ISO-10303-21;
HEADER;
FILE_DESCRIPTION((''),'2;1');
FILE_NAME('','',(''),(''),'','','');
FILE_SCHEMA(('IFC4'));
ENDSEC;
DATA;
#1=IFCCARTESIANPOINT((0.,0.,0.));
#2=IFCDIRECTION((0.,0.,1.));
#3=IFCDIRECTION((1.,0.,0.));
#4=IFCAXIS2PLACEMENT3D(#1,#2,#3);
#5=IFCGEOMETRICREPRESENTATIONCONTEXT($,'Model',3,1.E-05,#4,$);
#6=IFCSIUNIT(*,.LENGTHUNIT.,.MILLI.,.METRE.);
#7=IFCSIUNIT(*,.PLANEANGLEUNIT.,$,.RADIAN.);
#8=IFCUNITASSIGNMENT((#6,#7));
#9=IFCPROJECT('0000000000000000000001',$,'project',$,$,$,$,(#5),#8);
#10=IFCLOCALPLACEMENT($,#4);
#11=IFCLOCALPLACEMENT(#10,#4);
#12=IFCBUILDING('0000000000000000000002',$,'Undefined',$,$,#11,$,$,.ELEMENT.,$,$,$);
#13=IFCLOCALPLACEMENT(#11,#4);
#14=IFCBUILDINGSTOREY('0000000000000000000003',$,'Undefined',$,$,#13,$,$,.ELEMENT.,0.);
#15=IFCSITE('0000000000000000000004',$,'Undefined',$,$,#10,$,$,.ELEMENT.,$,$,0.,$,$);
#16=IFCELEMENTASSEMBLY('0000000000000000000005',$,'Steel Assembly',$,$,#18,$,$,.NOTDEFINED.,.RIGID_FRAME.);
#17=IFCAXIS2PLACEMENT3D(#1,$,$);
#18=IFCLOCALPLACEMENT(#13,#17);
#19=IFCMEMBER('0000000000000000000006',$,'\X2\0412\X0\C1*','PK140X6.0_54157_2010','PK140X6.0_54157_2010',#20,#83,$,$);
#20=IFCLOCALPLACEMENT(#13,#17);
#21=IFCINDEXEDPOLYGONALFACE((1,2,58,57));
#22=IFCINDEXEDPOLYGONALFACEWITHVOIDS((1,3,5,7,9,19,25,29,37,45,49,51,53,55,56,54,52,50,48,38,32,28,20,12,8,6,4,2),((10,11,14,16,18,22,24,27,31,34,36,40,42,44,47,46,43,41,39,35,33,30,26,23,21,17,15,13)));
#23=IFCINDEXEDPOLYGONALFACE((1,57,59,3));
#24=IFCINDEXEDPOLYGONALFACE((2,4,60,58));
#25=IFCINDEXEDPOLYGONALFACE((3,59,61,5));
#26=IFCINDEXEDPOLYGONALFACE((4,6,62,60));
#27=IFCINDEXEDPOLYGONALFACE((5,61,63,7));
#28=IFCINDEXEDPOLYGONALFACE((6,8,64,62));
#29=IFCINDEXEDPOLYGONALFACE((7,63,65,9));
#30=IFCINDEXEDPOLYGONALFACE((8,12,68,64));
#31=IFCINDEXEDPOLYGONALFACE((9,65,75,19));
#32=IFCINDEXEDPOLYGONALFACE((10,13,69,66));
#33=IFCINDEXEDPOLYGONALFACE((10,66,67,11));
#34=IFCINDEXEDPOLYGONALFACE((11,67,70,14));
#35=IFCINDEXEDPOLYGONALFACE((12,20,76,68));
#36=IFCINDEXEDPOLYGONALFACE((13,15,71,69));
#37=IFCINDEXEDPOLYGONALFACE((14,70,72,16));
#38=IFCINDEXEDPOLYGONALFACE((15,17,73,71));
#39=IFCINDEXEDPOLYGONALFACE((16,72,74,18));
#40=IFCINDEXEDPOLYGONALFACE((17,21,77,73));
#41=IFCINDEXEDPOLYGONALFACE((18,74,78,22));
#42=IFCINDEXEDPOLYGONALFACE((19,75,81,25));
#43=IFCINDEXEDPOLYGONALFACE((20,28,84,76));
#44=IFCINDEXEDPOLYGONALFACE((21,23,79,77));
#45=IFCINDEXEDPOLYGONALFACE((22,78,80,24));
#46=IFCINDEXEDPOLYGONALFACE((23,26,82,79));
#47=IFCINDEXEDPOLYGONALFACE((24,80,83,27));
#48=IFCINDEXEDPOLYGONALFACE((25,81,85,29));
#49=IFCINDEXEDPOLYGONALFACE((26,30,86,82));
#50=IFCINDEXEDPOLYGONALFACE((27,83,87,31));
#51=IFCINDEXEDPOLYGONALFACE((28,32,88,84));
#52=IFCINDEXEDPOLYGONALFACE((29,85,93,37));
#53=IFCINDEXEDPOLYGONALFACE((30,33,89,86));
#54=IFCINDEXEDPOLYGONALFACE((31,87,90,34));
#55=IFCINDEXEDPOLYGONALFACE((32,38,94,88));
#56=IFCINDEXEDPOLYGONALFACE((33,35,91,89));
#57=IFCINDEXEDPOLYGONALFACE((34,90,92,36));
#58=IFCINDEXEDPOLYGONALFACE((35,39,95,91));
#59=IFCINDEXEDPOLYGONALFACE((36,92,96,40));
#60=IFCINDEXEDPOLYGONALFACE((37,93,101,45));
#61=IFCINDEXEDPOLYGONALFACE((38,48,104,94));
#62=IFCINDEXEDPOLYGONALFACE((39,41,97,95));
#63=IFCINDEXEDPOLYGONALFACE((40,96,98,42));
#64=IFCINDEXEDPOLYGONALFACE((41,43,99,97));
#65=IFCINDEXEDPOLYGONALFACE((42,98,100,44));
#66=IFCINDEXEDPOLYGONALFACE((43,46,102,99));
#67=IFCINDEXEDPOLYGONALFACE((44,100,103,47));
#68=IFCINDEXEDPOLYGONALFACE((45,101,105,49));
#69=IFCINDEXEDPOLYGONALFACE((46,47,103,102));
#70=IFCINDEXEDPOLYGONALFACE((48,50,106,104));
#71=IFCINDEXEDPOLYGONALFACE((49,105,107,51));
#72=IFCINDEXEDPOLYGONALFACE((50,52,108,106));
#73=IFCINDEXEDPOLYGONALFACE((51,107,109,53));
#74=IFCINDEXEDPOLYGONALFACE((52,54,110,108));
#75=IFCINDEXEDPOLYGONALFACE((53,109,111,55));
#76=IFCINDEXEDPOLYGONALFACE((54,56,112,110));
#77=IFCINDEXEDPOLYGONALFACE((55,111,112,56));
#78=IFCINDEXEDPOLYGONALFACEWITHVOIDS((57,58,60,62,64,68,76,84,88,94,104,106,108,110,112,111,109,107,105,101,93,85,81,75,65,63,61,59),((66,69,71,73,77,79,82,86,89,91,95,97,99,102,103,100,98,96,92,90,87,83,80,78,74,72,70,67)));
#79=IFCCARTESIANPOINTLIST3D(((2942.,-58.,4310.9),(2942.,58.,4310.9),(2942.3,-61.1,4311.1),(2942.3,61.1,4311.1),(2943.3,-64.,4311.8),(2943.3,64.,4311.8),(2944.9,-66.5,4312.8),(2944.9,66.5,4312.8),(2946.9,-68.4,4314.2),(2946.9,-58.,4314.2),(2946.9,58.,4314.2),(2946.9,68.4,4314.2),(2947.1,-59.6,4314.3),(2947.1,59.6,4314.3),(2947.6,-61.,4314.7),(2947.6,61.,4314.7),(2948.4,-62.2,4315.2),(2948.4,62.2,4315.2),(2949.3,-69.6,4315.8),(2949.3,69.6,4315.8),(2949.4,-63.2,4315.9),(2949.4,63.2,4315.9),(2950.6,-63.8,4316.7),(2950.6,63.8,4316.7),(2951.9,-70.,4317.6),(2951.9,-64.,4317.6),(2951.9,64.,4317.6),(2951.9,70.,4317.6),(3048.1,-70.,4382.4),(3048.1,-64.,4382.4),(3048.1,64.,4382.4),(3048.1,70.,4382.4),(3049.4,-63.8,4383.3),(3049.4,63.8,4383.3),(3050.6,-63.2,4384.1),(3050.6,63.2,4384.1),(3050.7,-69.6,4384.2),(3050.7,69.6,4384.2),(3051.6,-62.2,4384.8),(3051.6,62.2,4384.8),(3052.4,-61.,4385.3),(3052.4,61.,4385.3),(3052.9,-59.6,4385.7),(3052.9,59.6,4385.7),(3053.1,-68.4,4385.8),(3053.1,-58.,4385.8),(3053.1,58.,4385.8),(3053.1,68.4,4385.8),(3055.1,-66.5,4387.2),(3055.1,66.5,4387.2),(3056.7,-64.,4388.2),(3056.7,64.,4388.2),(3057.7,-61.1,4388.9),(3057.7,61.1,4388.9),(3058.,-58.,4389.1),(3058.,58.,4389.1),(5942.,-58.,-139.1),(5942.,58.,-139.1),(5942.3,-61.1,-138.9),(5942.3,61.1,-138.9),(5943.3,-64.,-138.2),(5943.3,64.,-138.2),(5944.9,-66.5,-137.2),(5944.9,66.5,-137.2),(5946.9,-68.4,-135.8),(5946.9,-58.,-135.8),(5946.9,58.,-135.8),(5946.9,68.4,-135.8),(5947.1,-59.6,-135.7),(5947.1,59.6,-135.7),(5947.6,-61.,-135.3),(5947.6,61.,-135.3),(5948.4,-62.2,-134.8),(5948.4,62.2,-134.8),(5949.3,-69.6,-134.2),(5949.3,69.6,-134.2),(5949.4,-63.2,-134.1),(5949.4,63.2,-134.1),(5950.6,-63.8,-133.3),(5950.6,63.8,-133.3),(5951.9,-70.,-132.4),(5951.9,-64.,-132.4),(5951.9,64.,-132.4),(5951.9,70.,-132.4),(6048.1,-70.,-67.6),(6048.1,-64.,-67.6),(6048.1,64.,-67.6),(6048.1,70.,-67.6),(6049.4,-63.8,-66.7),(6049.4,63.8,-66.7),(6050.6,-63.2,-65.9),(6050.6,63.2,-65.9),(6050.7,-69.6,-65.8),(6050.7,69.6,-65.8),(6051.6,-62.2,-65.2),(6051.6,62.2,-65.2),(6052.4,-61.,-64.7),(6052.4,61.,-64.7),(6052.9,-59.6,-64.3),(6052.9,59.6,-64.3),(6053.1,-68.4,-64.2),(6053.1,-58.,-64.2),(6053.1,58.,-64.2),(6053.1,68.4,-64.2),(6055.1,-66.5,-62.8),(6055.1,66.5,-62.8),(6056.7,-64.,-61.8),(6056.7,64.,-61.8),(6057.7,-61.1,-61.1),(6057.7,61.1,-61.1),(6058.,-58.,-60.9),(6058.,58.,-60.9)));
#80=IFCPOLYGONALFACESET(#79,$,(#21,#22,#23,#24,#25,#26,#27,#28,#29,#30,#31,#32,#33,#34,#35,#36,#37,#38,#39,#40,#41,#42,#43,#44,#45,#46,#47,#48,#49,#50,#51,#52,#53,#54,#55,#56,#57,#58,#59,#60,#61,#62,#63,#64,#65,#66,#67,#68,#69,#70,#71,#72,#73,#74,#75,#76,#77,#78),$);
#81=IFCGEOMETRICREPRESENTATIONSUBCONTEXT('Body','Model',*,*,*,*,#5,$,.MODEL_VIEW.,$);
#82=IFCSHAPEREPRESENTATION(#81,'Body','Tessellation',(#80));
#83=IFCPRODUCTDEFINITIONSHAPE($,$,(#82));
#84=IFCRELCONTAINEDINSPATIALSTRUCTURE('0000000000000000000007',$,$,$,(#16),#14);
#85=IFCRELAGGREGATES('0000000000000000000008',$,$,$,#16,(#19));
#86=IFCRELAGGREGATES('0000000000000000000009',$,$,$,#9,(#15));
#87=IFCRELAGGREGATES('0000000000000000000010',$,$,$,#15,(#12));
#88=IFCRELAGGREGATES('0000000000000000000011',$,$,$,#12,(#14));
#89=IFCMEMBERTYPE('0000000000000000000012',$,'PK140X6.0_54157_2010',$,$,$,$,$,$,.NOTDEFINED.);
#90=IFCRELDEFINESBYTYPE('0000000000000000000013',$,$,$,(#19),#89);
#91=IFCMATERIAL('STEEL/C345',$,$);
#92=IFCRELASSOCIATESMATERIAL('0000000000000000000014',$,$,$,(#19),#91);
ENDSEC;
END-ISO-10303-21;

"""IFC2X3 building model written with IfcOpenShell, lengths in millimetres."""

from ifc_helpers import new_model, si_unit, frame, origin_with_axes, origin_2d_with_axis, place, context, subcontext, project, spatial, hollow_rectangle, extrude, material, type_object, element, aggregate, save


model = new_model("IFC2X3")

# Units and contexts
model_context = context("Model", 3, precision=1e-05, world=origin_with_axes())
body_context = subcontext(model_context, "Body", "Model", "MODEL_VIEW")
ifc_project = project(units=[si_unit("LENGTHUNIT", "METRE", prefix="MILLI"), si_unit("PLANEANGLEUNIT", "RADIAN")], contexts=[model_context])

# Site, building, storey
site_placement = place(None, origin_with_axes())
site = spatial("IfcSite", under=ifc_project, at=site_placement, Name="Undefined", CompositionType="ELEMENT", RefElevation=0.0)
building_placement = place(site_placement, origin_with_axes())
building = spatial("IfcBuilding", under=site, at=building_placement, Name="Undefined", CompositionType="ELEMENT")
storey_placement = place(building_placement, origin_with_axes())
storey = spatial("IfcBuildingStorey", under=building, at=storey_placement, Name="Undefined", CompositionType="ELEMENT", Elevation=0.0)

# Shared definitions
ifc_material_1 = material(Name="STEEL/C345")

# Element assembly, member
assembly_1_placement = place(storey_placement, origin_with_axes())
assembly_1 = element("IfcElementAssembly", 1, at=assembly_1_placement, inside=storey, Name="Steel Assembly", AssemblyPlace="NOTDEFINED", PredefinedType="RIGID_FRAME")
member_type = type_object("IfcMemberType", Name="PK140X6.0_54157_2010", PredefinedType="NOTDEFINED")
member_placement = place(assembly_1_placement, frame((6000.0, 0.0, -100.0), z_axis=(0.829173, 0.0, 0.558993), x_axis=(-0.558993, 0.0, 0.829173)))
member = element("IfcMember", 2, at=member_placement, type_object=member_type, material=ifc_material_1, Name="ВC1*", Description="PK140X6.0_54157_2010", ObjectType="PK140X6.0_54157_2010", context=body_context, shape_type="SweptSolid", body=[
    extrude(hollow_rectangle(XDim=140.0, YDim=140.0, WallThickness=6.0, InnerFilletRadius=6.0, OuterFilletRadius=12.0, at=origin_2d_with_axis()), frame((5366.8, 0.0, 0.0), z_axis=(-1.0, 0.0, 0.0), x_axis=(0.0, -1.0, 0.0)), (0.0, 0.0, 1.0), 5366.8),
])
aggregate(assembly_1, [member])

save(model, "model.ifc")
